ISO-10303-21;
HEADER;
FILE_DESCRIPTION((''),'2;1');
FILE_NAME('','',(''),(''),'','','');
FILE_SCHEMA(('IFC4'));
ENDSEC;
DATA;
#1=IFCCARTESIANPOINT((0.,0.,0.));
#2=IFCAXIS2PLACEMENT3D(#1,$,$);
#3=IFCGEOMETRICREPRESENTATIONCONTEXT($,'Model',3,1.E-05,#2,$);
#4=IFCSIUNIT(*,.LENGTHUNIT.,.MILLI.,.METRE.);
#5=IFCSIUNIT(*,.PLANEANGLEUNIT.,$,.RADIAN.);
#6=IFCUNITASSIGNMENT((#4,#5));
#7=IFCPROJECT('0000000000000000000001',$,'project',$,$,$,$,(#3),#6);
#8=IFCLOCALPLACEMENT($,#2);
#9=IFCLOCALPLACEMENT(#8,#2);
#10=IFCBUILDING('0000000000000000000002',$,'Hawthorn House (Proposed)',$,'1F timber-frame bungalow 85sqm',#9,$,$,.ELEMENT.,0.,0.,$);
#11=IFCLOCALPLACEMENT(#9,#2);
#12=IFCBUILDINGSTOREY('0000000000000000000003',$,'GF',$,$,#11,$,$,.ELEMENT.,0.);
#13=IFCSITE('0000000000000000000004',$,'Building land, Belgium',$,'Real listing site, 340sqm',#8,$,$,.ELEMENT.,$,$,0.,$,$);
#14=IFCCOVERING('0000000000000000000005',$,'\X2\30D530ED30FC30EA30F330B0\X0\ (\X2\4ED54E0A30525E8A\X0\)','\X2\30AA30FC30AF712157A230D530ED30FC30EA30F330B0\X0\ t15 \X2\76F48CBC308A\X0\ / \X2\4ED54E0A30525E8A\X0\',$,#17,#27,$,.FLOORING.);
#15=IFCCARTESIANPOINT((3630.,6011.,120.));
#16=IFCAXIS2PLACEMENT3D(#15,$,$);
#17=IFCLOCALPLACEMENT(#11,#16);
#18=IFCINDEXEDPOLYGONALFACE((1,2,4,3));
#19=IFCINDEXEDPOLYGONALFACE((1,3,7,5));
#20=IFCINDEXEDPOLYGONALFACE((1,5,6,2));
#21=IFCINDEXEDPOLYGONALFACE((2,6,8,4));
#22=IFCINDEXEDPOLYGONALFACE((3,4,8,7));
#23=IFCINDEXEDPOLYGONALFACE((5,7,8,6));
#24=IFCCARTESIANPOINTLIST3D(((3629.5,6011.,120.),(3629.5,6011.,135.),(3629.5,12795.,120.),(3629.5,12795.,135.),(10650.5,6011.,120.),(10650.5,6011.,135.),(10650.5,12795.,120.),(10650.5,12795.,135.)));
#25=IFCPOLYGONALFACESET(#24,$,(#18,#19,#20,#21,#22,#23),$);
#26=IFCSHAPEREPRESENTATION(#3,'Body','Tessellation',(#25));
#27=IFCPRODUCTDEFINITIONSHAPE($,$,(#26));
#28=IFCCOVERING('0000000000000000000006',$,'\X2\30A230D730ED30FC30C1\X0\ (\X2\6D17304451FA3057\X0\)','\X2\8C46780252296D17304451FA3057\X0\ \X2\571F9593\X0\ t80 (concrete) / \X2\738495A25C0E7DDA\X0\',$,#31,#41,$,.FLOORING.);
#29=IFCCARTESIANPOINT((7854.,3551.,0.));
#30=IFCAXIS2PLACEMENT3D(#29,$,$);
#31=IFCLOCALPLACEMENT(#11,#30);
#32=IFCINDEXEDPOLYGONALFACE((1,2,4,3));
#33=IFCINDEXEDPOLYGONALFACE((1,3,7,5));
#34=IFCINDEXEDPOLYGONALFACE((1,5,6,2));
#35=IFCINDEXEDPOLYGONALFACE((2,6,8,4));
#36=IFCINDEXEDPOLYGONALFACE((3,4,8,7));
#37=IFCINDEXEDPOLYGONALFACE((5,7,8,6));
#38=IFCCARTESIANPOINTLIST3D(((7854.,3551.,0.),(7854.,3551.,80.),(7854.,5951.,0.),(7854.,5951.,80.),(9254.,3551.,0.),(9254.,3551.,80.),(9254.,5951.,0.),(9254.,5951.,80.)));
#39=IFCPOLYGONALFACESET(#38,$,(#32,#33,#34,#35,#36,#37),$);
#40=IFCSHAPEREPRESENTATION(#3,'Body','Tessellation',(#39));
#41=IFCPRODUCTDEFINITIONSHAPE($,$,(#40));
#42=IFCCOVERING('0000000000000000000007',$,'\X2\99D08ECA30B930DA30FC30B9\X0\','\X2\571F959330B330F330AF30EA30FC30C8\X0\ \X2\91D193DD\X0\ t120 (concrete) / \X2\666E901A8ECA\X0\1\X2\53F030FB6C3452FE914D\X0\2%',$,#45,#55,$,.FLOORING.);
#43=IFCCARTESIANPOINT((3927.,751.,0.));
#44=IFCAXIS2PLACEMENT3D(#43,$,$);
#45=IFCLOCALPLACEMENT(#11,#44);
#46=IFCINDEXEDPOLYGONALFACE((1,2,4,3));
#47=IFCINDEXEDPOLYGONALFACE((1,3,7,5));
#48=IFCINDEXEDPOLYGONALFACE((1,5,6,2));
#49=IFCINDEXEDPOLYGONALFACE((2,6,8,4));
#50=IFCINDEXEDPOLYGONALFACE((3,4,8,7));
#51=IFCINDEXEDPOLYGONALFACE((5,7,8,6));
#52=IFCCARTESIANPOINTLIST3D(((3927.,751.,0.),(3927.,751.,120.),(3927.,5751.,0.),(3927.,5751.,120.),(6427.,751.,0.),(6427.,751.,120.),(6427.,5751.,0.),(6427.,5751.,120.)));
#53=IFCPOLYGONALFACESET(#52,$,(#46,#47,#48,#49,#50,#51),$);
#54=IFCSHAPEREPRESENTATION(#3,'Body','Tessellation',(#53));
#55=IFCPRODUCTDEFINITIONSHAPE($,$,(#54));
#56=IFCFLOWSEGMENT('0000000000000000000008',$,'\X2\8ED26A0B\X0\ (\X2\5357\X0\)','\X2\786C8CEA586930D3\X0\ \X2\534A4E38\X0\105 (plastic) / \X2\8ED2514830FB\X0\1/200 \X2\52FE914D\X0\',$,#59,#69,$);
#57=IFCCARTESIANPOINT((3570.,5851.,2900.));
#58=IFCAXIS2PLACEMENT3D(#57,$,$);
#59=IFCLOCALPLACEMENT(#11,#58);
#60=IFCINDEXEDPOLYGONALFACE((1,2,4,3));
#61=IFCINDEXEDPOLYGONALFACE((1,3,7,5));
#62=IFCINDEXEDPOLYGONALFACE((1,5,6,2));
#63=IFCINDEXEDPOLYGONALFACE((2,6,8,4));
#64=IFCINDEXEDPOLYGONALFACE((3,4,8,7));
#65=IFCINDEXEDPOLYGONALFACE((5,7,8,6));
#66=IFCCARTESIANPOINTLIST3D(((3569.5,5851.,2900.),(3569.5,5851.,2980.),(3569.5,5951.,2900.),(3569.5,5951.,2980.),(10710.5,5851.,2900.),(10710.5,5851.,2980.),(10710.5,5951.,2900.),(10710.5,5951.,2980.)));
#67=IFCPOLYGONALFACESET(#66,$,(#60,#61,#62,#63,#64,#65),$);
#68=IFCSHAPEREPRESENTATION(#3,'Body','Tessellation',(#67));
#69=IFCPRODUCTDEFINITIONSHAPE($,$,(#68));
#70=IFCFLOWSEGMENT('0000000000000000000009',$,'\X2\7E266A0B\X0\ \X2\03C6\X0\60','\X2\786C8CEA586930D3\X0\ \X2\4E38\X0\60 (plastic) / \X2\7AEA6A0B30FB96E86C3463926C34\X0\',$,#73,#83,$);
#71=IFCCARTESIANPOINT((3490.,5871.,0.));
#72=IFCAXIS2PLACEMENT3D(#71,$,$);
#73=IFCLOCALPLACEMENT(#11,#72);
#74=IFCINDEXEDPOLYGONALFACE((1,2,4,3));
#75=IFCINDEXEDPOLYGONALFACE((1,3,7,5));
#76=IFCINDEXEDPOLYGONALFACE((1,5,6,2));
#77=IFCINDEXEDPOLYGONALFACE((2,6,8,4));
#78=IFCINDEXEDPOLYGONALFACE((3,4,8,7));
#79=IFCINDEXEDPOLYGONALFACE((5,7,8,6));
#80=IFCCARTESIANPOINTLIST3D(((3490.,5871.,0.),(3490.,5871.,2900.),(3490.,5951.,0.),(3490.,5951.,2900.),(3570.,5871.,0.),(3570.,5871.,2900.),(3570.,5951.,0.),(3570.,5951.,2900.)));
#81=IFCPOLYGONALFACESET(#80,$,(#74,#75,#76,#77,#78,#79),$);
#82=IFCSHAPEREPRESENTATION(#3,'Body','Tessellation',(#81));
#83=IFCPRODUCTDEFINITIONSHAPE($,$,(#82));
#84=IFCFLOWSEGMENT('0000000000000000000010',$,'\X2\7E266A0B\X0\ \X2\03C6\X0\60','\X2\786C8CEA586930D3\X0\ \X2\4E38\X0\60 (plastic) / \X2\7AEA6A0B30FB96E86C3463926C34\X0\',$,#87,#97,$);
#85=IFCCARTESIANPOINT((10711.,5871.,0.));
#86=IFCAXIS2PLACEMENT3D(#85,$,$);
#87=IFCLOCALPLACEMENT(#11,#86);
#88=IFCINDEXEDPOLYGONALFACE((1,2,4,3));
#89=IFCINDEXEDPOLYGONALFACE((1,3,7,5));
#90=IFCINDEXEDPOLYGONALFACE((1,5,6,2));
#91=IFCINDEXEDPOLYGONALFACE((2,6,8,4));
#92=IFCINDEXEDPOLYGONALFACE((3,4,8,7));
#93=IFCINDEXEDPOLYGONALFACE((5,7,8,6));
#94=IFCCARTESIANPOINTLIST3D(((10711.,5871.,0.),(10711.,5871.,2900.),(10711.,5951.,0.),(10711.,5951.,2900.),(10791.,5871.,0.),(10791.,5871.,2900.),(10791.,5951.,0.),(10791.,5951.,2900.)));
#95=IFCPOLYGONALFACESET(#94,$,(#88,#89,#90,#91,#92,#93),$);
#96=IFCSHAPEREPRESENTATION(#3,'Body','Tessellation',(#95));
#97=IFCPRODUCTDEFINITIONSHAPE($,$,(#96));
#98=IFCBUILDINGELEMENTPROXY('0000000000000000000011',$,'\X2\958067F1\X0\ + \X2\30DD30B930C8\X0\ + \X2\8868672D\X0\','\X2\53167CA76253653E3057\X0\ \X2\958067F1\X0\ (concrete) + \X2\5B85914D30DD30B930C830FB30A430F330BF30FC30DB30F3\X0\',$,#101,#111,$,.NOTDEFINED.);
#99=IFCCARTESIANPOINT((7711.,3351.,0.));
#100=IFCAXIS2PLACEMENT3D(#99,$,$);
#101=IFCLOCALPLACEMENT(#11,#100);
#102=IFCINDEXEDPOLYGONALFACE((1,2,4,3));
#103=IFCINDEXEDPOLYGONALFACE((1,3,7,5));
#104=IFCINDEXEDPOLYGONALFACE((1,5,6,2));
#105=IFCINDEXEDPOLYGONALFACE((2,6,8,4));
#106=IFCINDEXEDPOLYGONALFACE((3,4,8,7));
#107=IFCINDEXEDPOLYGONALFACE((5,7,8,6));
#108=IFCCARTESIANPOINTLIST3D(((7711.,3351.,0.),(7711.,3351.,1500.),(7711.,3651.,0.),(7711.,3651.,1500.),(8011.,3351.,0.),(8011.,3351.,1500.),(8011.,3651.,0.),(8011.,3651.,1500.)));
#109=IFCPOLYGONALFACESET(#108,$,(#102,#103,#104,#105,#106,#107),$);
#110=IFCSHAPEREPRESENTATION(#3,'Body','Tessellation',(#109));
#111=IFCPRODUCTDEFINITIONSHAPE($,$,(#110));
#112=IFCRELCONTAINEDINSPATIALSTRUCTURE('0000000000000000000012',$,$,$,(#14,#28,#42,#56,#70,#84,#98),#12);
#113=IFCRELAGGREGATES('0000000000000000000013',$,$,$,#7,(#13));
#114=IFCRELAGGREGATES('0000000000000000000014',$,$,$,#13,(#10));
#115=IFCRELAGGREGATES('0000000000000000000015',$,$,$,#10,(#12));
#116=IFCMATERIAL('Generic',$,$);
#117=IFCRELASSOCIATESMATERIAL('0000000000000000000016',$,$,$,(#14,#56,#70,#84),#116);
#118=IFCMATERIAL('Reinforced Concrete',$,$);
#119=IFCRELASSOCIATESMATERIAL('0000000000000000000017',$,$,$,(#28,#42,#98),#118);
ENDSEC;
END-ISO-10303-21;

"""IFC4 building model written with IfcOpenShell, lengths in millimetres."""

from ifc_helpers import new_model, si_unit, frame, frame_2d, origin, place, context, project, spatial, rectangle, extrude, material, element, save


model = new_model("IFC4")

# Units and contexts
model_context = context("Model", 3, precision=1e-05, world=origin())
ifc_project = project(units=[si_unit("LENGTHUNIT", "METRE", prefix="MILLI"), si_unit("PLANEANGLEUNIT", "RADIAN")], contexts=[model_context])

# Site, building, storey
site_placement = place(None, origin())
site = spatial("IfcSite", under=ifc_project, at=site_placement, Name="Building land, Belgium", ObjectType="Real listing site, 340sqm", CompositionType="ELEMENT", RefElevation=0.0)
building_placement = place(site_placement, origin())
building = spatial("IfcBuilding", under=site, at=building_placement, Name="Hawthorn House (Proposed)", ObjectType="1F timber-frame bungalow 85sqm", CompositionType="ELEMENT", ElevationOfRefHeight=0.0, ElevationOfTerrain=0.0)
storey_placement = place(building_placement, origin())
storey = spatial("IfcBuildingStorey", under=building, at=storey_placement, Name="GF", CompositionType="ELEMENT", Elevation=0.0)

# Shared definitions
ifc_material_1 = material(Name="Reinforced Concrete")

# Coverings
ifc_material_2 = material(Name="Generic")
covering_1_placement = place(storey_placement, frame((3630.0, 6011.0, 120.0)))
element("IfcCovering", 1, at=covering_1_placement, inside=storey, material=ifc_material_2, Name="フローリング (仕上げ床)", Description="オーク無垢フローリング t15 直貼り / 仕上げ床", PredefinedType="FLOORING", context=model_context, shape_type="SweptSolid", body=[
    extrude(rectangle(XDim=7021.0, YDim=6784.0, at=frame_2d((3510.0, 3392.0))), frame((3630.0, 6011.0, 120.0)), (0.0, 0.0, 1.0), 15.0),
])
covering_2_placement = place(storey_placement, frame((7854.0, 3551.0, 0.0)))
element("IfcCovering", 2, at=covering_2_placement, inside=storey, material=ifc_material_1, Name="アプローチ (洗い出し)", Description="豆砂利洗い出し 土間 t80 (concrete) / 玄関導線", PredefinedType="FLOORING", context=model_context, shape_type="SweptSolid", body=[
    extrude(rectangle(XDim=1400.0, YDim=2400.0, at=frame_2d((700.0, 1200.0))), frame((7854.0, 3551.0, 0.0)), (0.0, 0.0, 1.0), 80.0),
])
covering_3_placement = place(storey_placement, frame((3927.0, 751.0, 0.0)))
element("IfcCovering", 3, at=covering_3_placement, inside=storey, material=ifc_material_1, Name="駐車スペース", Description="土間コンクリート 金鏝 t120 (concrete) / 普通車1台・水勾配2%", PredefinedType="FLOORING", context=model_context, shape_type="SweptSolid", body=[
    extrude(rectangle(XDim=2500.0, YDim=5000.0, at=frame_2d((1250.0, 2500.0))), frame((3927.0, 751.0, 0.0)), (0.0, 0.0, 1.0), 120.0),
])

# Flow segments
flow_segment_1_placement = place(storey_placement, frame((3570.0, 5851.0, 2900.0)))
element("IfcFlowSegment", 4, at=flow_segment_1_placement, inside=storey, material=ifc_material_2, Name="軒樋 (南)", Description="硬質塩ビ 半丸105 (plastic) / 軒先・1/200 勾配", context=model_context, shape_type="SweptSolid", body=[
    extrude(rectangle(XDim=7141.0, YDim=100.0, at=frame_2d((3570.0, 50.0))), frame((3570.0, 5851.0, 2900.0)), (0.0, 0.0, 1.0), 80.0),
])
flow_segment_2_placement = place(storey_placement, frame((3490.0, 5871.0, 0.0)))
element("IfcFlowSegment", 5, at=flow_segment_2_placement, inside=storey, material=ifc_material_2, Name="縦樋 φ60", Description="硬質塩ビ 丸60 (plastic) / 竪樋・雨水排水", context=model_context, shape_type="SweptSolid", body=[
    extrude(rectangle(XDim=80.0, YDim=80.0, at=frame_2d((40.0, 40.0))), frame((3490.0, 5871.0, 0.0)), (0.0, 0.0, 1.0), 2900.0),
])
flow_segment_3_placement = place(storey_placement, frame((10711.0, 5871.0, 0.0)))
element("IfcFlowSegment", 6, at=flow_segment_3_placement, inside=storey, material=ifc_material_2, Name="縦樋 φ60", Description="硬質塩ビ 丸60 (plastic) / 竪樋・雨水排水", context=model_context, shape_type="SweptSolid", body=[
    extrude(rectangle(XDim=80.0, YDim=80.0, at=frame_2d((40.0, 40.0))), frame((10711.0, 5871.0, 0.0)), (0.0, 0.0, 1.0), 2900.0),
])

# Building element proxy
proxy_placement = place(storey_placement, frame((7711.0, 3351.0, 0.0)))
element("IfcBuildingElementProxy", 7, at=proxy_placement, inside=storey, material=ifc_material_1, Name="門柱 + ポスト + 表札", Description="化粧打放し 門柱 (concrete) + 宅配ポスト・インターホン", PredefinedType="NOTDEFINED", context=model_context, shape_type="SweptSolid", body=[
    extrude(rectangle(XDim=300.0, YDim=300.0, at=frame_2d((150.0, 150.0))), frame((7711.0, 3351.0, 0.0)), (0.0, 0.0, 1.0), 1500.0),
])

save(model, "model.ifc")
